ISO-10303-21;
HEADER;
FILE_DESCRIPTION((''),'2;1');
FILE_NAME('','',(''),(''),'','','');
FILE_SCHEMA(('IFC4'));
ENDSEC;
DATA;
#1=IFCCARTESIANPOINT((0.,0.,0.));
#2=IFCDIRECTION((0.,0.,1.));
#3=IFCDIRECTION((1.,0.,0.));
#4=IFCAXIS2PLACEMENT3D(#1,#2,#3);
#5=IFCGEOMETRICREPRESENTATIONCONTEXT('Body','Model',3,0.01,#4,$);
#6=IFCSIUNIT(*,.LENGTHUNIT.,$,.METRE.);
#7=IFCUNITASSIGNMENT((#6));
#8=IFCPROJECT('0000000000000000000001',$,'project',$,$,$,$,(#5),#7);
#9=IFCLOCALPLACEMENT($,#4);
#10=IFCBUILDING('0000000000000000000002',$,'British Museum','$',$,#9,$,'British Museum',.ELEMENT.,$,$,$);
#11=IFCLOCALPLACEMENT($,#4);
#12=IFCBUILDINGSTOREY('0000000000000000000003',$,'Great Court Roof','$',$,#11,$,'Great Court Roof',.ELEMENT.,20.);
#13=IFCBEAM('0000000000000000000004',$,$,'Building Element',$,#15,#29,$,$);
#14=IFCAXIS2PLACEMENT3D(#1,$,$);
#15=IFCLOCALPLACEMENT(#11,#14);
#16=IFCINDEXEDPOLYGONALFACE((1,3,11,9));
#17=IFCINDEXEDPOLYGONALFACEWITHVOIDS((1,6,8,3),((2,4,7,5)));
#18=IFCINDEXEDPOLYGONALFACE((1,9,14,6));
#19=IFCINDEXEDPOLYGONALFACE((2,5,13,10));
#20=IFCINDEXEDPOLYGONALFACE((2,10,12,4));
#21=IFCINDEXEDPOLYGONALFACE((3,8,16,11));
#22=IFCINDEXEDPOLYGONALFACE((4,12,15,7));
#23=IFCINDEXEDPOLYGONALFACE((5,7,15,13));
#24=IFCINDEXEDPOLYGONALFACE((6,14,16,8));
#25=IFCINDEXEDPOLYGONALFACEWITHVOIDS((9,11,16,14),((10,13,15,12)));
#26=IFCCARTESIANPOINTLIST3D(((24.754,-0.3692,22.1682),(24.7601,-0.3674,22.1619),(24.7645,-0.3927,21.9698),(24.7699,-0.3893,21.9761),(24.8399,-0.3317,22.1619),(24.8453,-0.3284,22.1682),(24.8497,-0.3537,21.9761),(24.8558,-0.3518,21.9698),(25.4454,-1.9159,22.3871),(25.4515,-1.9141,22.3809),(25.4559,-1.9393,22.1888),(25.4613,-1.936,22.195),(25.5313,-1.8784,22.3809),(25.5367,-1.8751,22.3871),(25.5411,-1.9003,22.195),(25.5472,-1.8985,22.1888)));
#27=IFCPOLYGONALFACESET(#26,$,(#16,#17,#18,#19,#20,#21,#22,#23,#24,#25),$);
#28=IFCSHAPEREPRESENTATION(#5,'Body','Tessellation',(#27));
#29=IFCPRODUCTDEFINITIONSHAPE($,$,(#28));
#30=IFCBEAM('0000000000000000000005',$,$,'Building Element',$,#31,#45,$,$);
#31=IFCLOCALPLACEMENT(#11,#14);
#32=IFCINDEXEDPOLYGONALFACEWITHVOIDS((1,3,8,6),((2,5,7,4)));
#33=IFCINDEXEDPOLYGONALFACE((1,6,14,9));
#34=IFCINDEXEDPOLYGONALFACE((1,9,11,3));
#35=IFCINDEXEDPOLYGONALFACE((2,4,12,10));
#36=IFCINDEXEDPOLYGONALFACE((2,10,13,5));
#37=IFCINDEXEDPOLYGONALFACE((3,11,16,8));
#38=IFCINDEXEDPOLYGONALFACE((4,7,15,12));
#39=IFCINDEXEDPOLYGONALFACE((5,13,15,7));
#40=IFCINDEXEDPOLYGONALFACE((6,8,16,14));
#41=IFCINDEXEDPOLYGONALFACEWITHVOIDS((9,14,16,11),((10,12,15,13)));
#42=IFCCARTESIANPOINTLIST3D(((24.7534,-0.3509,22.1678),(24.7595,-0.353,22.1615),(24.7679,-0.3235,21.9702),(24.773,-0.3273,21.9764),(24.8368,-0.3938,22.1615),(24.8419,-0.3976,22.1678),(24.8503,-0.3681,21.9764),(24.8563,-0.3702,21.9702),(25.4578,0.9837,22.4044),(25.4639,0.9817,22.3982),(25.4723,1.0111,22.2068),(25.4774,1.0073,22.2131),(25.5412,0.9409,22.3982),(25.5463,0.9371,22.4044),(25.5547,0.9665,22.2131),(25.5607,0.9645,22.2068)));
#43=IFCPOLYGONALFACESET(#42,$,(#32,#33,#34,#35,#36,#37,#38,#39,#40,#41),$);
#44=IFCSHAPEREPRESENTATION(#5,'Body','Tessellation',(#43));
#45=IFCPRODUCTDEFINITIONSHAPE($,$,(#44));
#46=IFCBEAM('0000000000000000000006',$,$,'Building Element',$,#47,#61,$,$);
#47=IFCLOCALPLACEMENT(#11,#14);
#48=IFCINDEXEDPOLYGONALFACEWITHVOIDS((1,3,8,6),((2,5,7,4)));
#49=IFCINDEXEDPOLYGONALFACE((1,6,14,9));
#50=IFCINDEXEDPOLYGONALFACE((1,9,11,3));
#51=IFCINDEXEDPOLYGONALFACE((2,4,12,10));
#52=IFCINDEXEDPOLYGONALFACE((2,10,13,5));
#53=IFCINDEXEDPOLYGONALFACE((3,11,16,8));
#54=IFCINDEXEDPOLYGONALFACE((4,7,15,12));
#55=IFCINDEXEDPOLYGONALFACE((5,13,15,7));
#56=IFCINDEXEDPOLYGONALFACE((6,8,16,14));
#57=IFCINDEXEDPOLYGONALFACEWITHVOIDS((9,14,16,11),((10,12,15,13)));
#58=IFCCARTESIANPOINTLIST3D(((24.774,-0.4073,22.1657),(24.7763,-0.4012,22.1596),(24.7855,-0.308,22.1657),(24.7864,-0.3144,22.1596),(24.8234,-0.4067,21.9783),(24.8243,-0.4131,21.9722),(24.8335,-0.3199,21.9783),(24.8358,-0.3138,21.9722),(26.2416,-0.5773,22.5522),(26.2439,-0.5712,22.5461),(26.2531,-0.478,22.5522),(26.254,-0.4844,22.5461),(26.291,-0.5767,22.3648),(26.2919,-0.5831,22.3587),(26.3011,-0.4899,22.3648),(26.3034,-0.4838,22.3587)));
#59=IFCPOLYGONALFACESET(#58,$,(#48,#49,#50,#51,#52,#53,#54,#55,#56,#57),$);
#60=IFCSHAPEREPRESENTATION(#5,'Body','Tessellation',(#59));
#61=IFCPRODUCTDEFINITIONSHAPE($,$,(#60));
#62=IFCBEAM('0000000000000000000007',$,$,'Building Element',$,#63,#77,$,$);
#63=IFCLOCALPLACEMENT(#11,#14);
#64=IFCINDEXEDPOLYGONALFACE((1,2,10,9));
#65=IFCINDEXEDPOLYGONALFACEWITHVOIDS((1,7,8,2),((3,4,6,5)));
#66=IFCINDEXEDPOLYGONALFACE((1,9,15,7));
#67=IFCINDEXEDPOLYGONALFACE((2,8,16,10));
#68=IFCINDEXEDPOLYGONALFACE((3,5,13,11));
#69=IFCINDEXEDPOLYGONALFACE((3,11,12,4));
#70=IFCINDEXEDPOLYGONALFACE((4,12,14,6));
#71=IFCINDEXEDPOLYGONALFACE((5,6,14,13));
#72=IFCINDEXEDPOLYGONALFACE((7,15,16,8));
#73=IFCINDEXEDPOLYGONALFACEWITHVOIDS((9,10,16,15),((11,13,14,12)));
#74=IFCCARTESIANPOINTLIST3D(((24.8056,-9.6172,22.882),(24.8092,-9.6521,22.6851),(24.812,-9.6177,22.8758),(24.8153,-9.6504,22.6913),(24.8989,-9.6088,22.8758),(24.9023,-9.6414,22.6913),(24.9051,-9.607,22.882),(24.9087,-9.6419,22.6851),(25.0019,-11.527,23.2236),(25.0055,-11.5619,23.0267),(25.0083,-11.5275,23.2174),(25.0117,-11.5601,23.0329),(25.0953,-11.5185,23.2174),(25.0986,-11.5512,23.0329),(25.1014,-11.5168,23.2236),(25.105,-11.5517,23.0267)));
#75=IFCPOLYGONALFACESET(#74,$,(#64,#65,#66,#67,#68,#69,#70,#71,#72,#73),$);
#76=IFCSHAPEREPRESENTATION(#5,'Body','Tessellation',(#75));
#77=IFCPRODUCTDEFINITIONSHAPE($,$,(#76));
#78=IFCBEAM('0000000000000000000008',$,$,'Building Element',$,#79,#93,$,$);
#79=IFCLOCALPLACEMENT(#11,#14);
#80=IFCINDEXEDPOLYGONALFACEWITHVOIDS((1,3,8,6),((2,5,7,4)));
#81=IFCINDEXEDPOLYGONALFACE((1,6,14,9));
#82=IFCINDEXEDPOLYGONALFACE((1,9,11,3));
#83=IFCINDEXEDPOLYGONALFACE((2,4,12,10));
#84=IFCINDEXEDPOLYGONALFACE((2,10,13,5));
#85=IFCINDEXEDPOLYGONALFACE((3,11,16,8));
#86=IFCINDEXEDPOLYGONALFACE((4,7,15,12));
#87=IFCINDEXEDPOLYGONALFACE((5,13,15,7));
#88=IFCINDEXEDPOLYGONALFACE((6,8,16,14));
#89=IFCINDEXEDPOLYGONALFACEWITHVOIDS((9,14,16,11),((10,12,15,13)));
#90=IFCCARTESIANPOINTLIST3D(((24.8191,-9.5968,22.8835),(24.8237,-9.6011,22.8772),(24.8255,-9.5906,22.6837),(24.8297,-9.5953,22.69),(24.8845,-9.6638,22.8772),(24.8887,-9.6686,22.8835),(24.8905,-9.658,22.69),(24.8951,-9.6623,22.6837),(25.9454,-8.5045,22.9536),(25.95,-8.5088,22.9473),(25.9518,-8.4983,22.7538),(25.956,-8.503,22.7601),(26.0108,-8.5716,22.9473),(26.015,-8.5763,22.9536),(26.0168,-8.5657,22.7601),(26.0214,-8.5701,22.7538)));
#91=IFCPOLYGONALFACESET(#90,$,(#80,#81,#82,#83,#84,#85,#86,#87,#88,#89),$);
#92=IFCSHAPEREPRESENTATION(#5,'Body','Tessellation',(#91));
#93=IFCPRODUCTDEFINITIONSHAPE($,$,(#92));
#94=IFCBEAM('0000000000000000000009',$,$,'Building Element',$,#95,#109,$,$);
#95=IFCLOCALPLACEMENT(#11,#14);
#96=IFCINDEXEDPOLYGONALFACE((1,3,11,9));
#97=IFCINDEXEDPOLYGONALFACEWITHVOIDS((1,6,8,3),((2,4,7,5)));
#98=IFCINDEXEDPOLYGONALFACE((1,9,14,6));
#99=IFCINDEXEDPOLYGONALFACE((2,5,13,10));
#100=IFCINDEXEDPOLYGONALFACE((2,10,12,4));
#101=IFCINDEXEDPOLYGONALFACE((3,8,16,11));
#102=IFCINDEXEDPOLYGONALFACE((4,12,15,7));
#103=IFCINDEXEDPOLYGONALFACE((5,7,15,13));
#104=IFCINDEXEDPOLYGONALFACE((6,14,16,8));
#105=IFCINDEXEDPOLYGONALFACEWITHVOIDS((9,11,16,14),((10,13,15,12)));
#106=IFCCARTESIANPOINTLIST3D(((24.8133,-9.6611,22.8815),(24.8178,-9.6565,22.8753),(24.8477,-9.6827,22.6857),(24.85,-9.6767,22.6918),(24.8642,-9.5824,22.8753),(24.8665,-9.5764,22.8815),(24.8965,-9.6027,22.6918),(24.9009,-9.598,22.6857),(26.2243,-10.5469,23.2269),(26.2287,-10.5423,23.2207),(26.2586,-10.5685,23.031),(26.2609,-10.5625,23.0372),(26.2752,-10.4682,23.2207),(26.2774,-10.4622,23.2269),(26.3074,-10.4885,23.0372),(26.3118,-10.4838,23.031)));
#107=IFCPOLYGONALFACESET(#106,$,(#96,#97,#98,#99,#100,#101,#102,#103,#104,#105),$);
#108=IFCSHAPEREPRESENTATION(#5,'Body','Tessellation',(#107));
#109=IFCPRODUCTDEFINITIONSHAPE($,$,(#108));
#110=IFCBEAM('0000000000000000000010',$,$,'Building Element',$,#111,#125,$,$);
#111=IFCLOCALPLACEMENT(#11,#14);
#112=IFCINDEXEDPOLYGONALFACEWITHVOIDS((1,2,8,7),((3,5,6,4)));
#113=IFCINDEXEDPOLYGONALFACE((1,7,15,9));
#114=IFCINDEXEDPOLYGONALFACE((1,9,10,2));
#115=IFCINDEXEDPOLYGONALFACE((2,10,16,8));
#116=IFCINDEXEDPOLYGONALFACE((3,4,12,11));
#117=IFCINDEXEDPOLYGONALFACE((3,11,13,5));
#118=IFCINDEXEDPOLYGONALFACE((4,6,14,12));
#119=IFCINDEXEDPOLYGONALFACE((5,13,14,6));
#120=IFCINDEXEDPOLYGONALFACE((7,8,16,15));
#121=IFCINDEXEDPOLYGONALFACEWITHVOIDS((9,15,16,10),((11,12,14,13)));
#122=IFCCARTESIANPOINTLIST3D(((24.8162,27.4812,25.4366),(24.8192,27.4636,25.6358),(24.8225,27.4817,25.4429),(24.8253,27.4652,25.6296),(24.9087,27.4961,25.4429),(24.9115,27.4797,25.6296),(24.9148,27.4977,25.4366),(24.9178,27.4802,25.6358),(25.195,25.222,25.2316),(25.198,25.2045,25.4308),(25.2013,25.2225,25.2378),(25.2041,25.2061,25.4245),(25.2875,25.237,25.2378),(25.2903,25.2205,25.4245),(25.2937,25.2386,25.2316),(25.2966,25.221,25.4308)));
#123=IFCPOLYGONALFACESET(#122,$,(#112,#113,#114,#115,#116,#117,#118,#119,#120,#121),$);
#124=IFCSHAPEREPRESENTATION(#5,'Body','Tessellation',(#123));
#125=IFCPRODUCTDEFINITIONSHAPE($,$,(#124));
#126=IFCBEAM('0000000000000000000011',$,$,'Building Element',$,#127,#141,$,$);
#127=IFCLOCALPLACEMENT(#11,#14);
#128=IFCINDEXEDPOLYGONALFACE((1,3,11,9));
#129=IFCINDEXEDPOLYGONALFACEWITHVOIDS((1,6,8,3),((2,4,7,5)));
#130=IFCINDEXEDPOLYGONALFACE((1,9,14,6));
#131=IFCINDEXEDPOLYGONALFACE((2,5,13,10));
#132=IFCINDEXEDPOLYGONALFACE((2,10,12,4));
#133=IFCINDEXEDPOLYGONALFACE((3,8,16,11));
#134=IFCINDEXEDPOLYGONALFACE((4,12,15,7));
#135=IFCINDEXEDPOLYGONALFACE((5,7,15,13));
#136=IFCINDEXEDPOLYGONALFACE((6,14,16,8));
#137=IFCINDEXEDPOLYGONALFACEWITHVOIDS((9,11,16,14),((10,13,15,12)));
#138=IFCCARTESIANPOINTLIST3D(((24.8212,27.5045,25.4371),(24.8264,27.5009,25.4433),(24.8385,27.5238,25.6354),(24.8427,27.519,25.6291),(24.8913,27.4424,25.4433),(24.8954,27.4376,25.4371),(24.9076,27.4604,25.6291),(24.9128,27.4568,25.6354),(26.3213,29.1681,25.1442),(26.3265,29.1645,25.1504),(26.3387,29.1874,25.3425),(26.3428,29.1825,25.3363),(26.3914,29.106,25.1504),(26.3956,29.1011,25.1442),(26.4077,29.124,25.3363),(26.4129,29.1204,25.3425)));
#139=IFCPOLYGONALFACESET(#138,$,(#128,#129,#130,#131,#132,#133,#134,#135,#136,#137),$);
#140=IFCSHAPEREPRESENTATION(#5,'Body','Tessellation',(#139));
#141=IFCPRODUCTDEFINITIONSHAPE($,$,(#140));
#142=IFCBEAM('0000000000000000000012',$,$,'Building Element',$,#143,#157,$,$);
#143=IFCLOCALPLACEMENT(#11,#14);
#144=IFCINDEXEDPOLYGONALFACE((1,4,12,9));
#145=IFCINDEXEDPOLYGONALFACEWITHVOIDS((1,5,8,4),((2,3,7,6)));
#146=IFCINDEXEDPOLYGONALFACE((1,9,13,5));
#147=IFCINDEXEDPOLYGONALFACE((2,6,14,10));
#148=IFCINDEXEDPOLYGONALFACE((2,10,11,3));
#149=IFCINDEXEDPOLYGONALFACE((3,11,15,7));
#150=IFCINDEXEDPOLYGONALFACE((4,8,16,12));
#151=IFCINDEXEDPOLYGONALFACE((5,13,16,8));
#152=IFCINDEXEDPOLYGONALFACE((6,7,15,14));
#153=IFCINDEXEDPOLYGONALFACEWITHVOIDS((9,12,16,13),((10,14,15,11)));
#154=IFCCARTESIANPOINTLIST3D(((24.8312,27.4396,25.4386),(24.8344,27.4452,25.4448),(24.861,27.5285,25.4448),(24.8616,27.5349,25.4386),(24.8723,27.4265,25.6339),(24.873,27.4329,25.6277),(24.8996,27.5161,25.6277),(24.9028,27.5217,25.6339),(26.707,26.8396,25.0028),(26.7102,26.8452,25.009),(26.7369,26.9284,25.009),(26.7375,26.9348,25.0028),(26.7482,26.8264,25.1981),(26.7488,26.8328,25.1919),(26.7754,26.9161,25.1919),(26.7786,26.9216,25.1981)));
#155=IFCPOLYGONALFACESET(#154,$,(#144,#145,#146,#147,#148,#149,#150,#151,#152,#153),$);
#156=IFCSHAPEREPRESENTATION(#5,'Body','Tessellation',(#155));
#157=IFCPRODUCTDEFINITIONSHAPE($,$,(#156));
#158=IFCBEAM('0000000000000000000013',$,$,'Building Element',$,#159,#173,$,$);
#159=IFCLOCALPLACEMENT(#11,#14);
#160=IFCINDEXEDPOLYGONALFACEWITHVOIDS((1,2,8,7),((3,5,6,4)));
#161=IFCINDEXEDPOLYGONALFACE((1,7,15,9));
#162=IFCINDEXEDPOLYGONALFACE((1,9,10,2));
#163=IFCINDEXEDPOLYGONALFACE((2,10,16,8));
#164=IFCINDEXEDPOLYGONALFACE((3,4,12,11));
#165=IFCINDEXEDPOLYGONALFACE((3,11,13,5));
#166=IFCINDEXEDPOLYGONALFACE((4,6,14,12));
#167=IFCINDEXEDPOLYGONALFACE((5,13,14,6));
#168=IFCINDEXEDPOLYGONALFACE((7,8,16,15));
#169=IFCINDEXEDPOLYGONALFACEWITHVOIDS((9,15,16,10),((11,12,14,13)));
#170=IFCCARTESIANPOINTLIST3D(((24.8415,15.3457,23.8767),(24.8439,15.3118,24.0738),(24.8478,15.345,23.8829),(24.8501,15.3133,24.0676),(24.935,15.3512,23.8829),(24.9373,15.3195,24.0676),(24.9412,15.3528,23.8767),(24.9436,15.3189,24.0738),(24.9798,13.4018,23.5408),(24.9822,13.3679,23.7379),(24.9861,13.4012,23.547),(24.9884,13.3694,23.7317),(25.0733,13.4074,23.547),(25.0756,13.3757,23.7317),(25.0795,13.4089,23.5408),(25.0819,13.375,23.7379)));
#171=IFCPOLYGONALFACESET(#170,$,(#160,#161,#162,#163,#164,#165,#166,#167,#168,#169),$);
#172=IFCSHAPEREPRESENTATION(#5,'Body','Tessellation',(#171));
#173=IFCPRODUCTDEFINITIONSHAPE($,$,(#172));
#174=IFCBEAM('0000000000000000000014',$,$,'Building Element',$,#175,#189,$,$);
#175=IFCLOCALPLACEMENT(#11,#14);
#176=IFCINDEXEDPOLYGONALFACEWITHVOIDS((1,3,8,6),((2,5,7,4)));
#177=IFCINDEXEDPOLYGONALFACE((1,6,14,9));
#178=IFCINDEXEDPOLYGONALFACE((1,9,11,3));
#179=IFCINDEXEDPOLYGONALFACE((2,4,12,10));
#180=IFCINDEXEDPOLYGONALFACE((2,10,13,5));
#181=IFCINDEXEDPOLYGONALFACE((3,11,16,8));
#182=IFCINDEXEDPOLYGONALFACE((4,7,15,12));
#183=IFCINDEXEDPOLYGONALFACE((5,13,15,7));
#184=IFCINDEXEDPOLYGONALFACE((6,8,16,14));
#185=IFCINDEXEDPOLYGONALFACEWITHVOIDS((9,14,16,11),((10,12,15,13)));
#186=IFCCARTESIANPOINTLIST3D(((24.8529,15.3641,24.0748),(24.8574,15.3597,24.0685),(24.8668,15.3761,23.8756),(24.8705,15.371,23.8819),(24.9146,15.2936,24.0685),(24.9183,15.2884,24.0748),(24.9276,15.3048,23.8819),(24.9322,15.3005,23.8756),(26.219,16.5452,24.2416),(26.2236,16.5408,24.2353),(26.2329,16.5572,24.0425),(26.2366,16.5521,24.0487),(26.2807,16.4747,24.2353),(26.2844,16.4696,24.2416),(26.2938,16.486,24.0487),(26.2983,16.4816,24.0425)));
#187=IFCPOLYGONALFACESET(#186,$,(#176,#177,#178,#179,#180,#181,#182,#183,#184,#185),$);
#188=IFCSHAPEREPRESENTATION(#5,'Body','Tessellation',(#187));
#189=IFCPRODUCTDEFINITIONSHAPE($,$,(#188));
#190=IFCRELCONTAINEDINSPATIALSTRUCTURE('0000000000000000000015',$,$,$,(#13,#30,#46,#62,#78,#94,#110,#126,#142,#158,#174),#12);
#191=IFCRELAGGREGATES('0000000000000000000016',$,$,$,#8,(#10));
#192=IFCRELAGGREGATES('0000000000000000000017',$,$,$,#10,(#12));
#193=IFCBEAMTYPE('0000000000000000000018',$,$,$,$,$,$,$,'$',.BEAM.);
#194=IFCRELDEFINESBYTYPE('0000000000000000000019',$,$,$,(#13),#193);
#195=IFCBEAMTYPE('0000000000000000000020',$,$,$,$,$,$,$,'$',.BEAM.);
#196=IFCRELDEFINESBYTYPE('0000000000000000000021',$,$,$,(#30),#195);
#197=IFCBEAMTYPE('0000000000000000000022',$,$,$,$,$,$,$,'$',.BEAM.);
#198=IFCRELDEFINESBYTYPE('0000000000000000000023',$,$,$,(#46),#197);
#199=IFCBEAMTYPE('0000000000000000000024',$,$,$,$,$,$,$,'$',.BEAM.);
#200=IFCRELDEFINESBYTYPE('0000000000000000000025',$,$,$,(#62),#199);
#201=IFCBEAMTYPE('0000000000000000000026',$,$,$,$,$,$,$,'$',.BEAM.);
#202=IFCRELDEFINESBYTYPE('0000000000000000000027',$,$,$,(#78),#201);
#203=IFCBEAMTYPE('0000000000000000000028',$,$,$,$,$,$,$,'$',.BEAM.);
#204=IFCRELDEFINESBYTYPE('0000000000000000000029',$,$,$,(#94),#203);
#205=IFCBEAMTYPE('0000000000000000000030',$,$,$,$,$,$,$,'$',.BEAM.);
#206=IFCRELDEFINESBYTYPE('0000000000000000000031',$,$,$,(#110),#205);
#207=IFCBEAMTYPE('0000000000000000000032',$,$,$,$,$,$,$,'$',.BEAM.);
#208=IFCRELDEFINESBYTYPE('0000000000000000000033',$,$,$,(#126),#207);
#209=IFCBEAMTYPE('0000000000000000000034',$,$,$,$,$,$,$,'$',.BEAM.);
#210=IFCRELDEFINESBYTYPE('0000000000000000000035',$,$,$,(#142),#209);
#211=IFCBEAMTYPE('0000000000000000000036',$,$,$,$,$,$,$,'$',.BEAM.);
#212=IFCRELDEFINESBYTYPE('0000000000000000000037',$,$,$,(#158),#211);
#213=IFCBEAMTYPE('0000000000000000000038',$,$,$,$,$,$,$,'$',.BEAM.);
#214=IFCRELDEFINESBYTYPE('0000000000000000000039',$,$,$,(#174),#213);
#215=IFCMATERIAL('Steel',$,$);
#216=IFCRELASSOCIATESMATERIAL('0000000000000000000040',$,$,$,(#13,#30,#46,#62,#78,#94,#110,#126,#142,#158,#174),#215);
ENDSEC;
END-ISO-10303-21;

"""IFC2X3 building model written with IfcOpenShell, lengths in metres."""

from ifc_helpers import new_model, si_unit, frame, origin_with_axes, origin_2d, place, context, project, spatial, hollow_rectangle, extrude, material, type_object, element, save


model = new_model("IFC2X3")

# Units and contexts
model_context = context("Model", 3, precision=0.01, world=origin_with_axes(), identifier="Body")
ifc_project = project(units=[si_unit("LENGTHUNIT", "METRE")], contexts=[model_context])

# Building, storey
building_placement = place(None, origin_with_axes())
building = spatial("IfcBuilding", under=ifc_project, at=building_placement, Name="British Museum", Description="$", LongName="British Museum", CompositionType="ELEMENT")
storey_placement = place(None, origin_with_axes())
storey = spatial("IfcBuildingStorey", under=building, at=storey_placement, Name="Great Court Roof", Description="$", LongName="Great Court Roof", CompositionType="ELEMENT", Elevation=20.0)

# Beams
ifc_material = material(Name="Steel")
beam_type_1 = type_object("IfcBeamType", ElementType="$", PredefinedType="BEAM")
beam_1_placement = place(None, origin_with_axes())
element("IfcBeam", 1, at=beam_1_placement, inside=storey, type_object=beam_type_1, material=ifc_material, Description="Building Element", context=model_context, shape_type="SweptSolid", body=[
    extrude(hollow_rectangle(XDim=0.1, YDim=0.2, WallThickness=0.0063, InnerFilletRadius=-0.0063, OuterFilletRadius=0.0, at=origin_2d()), frame((24.8049, -0.3605, 22.069), z_axis=(0.404758, -0.905393, 0.128194), x_axis=(0.912926, 0.408125, 0.0)), (0.0, 0.0, 1.0), 1.7083),
])
beam_type_2 = type_object("IfcBeamType", ElementType="$", PredefinedType="BEAM")
beam_2_placement = place(None, origin_with_axes())
element("IfcBeam", 2, at=beam_2_placement, inside=storey, type_object=beam_type_2, material=ifc_material, Description="Building Element", context=model_context, shape_type="SweptSolid", body=[
    extrude(hollow_rectangle(XDim=0.1, YDim=0.2, WallThickness=0.0063, InnerFilletRadius=-0.0063, OuterFilletRadius=0.0, at=origin_2d()), frame((24.8049, -0.3605, 22.069), z_axis=(0.461123, 0.873707, 0.154926), x_axis=(-0.884385, 0.466759, 0.0)), (0.0, 0.0, 1.0), 1.5276),
])
beam_type_3 = type_object("IfcBeamType", ElementType="$", PredefinedType="BEAM")
beam_3_placement = place(None, origin_with_axes())
element("IfcBeam", 3, at=beam_3_placement, inside=storey, type_object=beam_type_3, material=ifc_material, Description="Building Element", context=model_context, shape_type="SweptSolid", body=[
    extrude(hollow_rectangle(XDim=0.1, YDim=0.2, WallThickness=0.0063, InnerFilletRadius=-0.0063, OuterFilletRadius=0.0, at=origin_2d()), frame((24.8049, -0.3605, 22.069), z_axis=(0.96102, -0.111326, 0.253075), x_axis=(0.115072, 0.993357, 0.0)), (0.0, 0.0, 1.0), 1.5271),
])
beam_type_4 = type_object("IfcBeamType", ElementType="$", PredefinedType="BEAM")
beam_4_placement = place(None, origin_with_axes())
element("IfcBeam", 4, at=beam_4_placement, inside=storey, type_object=beam_type_4, material=ifc_material, Description="Building Element", context=model_context, shape_type="SweptSolid", body=[
    extrude(hollow_rectangle(XDim=0.1, YDim=0.2, WallThickness=0.0063, InnerFilletRadius=-0.0063, OuterFilletRadius=0.0, at=origin_2d()), frame((24.8571, -9.6296, 22.7836), z_axis=(0.100693, -0.979374, 0.175176), x_axis=(0.994756, 0.102274, 0.0)), (0.0, 0.0, 1.0), 1.95),
])
beam_type_5 = type_object("IfcBeamType", ElementType="$", PredefinedType="BEAM")
beam_5_placement = place(None, origin_with_axes())
element("IfcBeam", 5, at=beam_5_placement, inside=storey, type_object=beam_type_5, material=ifc_material, Description="Building Element", context=model_context, shape_type="SweptSolid", body=[
    extrude(hollow_rectangle(XDim=0.1, YDim=0.2, WallThickness=0.0063, InnerFilletRadius=-0.0063, OuterFilletRadius=0.0, at=origin_2d()), frame((24.8571, -9.6296, 22.7836), z_axis=(0.717152, 0.695486, 0.044634), x_axis=(-0.69618, 0.717867, 0.0)), (0.0, 0.0, 1.0), 1.5705),
])
beam_type_6 = type_object("IfcBeamType", ElementType="$", PredefinedType="BEAM")
beam_6_placement = place(None, origin_with_axes())
element("IfcBeam", 6, at=beam_6_placement, inside=storey, type_object=beam_type_6, material=ifc_material, Description="Building Element", context=model_context, shape_type="SweptSolid", body=[
    extrude(hollow_rectangle(XDim=0.1, YDim=0.2, WallThickness=0.0063, InnerFilletRadius=-0.0063, OuterFilletRadius=0.0, at=origin_2d()), frame((24.8571, -9.6296, 22.7836), z_axis=(0.829287, -0.52065, 0.202994), x_axis=(0.531721, 0.84692, 0.0)), (0.0, 0.0, 1.0), 1.7014),
])
beam_type_7 = type_object("IfcBeamType", ElementType="$", PredefinedType="BEAM")
beam_7_placement = place(None, origin_with_axes())
element("IfcBeam", 7, at=beam_7_placement, inside=storey, type_object=beam_type_7, material=ifc_material, Description="Building Element", context=model_context, shape_type="SweptSolid", body=[
    extrude(hollow_rectangle(XDim=0.1, YDim=0.2, WallThickness=0.0063, InnerFilletRadius=-0.0063, OuterFilletRadius=0.0, at=origin_2d()), frame((24.867, 27.4807, 25.5362), z_axis=(0.164723, -0.982301, -0.089166), x_axis=(0.98623, 0.165381, 0.0)), (0.0, 0.0, 1.0), 2.2999),
])
beam_type_8 = type_object("IfcBeamType", ElementType="$", PredefinedType="BEAM")
beam_8_placement = place(None, origin_with_axes())
element("IfcBeam", 8, at=beam_8_placement, inside=storey, type_object=beam_type_8, material=ifc_material, Description="Building Element", context=model_context, shape_type="SweptSolid", body=[
    extrude(hollow_rectangle(XDim=0.1, YDim=0.2, WallThickness=0.0063, InnerFilletRadius=-0.0063, OuterFilletRadius=0.0, at=origin_2d()), frame((24.867, 27.4807, 25.5362), z_axis=(0.664028, 0.736382, -0.129646), x_axis=(-0.74265, 0.66968, 0.0)), (0.0, 0.0, 1.0), 2.2591),
])
beam_type_9 = type_object("IfcBeamType", ElementType="$", PredefinedType="BEAM")
beam_9_placement = place(None, origin_with_axes())
element("IfcBeam", 9, at=beam_9_placement, inside=storey, type_object=beam_type_9, material=ifc_material, Description="Building Element", context=model_context, shape_type="SweptSolid", body=[
    extrude(hollow_rectangle(XDim=0.1, YDim=0.2, WallThickness=0.0063, InnerFilletRadius=-0.0063, OuterFilletRadius=0.0, at=origin_2d()), frame((24.867, 27.4807, 25.5362), z_axis=(0.92996, -0.297491, -0.216043), x_axis=(0.304686, 0.952453, 0.0)), (0.0, 0.0, 1.0), 2.0171),
])
beam_type_10 = type_object("IfcBeamType", ElementType="$", PredefinedType="BEAM")
beam_10_placement = place(None, origin_with_axes())
element("IfcBeam", 10, at=beam_10_placement, inside=storey, type_object=beam_type_10, material=ifc_material, Description="Building Element", context=model_context, shape_type="SweptSolid", body=[
    extrude(hollow_rectangle(XDim=0.1, YDim=0.2, WallThickness=0.0063, InnerFilletRadius=-0.0063, OuterFilletRadius=0.0, at=origin_2d()), frame((24.8925, 15.3323, 23.9752), z_axis=(0.069944, -0.982982, -0.169866), x_axis=(0.997478, 0.070975, 0.0)), (0.0, 0.0, 1.0), 1.9775),
])
beam_type_11 = type_object("IfcBeamType", ElementType="$", PredefinedType="BEAM")
beam_11_placement = place(None, origin_with_axes())
element("IfcBeam", 11, at=beam_11_placement, inside=storey, type_object=beam_type_11, material=ifc_material, Description="Building Element", context=model_context, shape_type="SweptSolid", body=[
    extrude(hollow_rectangle(XDim=0.1, YDim=0.2, WallThickness=0.0063, InnerFilletRadius=-0.0063, OuterFilletRadius=0.0, at=origin_2d()), frame((24.8925, 15.3323, 23.9752), z_axis=(0.75326, 0.65126, 0.091977), x_axis=(-0.654033, 0.756466, 0.0)), (0.0, 0.0, 1.0), 1.8136),
])

save(model, "model.ifc")
